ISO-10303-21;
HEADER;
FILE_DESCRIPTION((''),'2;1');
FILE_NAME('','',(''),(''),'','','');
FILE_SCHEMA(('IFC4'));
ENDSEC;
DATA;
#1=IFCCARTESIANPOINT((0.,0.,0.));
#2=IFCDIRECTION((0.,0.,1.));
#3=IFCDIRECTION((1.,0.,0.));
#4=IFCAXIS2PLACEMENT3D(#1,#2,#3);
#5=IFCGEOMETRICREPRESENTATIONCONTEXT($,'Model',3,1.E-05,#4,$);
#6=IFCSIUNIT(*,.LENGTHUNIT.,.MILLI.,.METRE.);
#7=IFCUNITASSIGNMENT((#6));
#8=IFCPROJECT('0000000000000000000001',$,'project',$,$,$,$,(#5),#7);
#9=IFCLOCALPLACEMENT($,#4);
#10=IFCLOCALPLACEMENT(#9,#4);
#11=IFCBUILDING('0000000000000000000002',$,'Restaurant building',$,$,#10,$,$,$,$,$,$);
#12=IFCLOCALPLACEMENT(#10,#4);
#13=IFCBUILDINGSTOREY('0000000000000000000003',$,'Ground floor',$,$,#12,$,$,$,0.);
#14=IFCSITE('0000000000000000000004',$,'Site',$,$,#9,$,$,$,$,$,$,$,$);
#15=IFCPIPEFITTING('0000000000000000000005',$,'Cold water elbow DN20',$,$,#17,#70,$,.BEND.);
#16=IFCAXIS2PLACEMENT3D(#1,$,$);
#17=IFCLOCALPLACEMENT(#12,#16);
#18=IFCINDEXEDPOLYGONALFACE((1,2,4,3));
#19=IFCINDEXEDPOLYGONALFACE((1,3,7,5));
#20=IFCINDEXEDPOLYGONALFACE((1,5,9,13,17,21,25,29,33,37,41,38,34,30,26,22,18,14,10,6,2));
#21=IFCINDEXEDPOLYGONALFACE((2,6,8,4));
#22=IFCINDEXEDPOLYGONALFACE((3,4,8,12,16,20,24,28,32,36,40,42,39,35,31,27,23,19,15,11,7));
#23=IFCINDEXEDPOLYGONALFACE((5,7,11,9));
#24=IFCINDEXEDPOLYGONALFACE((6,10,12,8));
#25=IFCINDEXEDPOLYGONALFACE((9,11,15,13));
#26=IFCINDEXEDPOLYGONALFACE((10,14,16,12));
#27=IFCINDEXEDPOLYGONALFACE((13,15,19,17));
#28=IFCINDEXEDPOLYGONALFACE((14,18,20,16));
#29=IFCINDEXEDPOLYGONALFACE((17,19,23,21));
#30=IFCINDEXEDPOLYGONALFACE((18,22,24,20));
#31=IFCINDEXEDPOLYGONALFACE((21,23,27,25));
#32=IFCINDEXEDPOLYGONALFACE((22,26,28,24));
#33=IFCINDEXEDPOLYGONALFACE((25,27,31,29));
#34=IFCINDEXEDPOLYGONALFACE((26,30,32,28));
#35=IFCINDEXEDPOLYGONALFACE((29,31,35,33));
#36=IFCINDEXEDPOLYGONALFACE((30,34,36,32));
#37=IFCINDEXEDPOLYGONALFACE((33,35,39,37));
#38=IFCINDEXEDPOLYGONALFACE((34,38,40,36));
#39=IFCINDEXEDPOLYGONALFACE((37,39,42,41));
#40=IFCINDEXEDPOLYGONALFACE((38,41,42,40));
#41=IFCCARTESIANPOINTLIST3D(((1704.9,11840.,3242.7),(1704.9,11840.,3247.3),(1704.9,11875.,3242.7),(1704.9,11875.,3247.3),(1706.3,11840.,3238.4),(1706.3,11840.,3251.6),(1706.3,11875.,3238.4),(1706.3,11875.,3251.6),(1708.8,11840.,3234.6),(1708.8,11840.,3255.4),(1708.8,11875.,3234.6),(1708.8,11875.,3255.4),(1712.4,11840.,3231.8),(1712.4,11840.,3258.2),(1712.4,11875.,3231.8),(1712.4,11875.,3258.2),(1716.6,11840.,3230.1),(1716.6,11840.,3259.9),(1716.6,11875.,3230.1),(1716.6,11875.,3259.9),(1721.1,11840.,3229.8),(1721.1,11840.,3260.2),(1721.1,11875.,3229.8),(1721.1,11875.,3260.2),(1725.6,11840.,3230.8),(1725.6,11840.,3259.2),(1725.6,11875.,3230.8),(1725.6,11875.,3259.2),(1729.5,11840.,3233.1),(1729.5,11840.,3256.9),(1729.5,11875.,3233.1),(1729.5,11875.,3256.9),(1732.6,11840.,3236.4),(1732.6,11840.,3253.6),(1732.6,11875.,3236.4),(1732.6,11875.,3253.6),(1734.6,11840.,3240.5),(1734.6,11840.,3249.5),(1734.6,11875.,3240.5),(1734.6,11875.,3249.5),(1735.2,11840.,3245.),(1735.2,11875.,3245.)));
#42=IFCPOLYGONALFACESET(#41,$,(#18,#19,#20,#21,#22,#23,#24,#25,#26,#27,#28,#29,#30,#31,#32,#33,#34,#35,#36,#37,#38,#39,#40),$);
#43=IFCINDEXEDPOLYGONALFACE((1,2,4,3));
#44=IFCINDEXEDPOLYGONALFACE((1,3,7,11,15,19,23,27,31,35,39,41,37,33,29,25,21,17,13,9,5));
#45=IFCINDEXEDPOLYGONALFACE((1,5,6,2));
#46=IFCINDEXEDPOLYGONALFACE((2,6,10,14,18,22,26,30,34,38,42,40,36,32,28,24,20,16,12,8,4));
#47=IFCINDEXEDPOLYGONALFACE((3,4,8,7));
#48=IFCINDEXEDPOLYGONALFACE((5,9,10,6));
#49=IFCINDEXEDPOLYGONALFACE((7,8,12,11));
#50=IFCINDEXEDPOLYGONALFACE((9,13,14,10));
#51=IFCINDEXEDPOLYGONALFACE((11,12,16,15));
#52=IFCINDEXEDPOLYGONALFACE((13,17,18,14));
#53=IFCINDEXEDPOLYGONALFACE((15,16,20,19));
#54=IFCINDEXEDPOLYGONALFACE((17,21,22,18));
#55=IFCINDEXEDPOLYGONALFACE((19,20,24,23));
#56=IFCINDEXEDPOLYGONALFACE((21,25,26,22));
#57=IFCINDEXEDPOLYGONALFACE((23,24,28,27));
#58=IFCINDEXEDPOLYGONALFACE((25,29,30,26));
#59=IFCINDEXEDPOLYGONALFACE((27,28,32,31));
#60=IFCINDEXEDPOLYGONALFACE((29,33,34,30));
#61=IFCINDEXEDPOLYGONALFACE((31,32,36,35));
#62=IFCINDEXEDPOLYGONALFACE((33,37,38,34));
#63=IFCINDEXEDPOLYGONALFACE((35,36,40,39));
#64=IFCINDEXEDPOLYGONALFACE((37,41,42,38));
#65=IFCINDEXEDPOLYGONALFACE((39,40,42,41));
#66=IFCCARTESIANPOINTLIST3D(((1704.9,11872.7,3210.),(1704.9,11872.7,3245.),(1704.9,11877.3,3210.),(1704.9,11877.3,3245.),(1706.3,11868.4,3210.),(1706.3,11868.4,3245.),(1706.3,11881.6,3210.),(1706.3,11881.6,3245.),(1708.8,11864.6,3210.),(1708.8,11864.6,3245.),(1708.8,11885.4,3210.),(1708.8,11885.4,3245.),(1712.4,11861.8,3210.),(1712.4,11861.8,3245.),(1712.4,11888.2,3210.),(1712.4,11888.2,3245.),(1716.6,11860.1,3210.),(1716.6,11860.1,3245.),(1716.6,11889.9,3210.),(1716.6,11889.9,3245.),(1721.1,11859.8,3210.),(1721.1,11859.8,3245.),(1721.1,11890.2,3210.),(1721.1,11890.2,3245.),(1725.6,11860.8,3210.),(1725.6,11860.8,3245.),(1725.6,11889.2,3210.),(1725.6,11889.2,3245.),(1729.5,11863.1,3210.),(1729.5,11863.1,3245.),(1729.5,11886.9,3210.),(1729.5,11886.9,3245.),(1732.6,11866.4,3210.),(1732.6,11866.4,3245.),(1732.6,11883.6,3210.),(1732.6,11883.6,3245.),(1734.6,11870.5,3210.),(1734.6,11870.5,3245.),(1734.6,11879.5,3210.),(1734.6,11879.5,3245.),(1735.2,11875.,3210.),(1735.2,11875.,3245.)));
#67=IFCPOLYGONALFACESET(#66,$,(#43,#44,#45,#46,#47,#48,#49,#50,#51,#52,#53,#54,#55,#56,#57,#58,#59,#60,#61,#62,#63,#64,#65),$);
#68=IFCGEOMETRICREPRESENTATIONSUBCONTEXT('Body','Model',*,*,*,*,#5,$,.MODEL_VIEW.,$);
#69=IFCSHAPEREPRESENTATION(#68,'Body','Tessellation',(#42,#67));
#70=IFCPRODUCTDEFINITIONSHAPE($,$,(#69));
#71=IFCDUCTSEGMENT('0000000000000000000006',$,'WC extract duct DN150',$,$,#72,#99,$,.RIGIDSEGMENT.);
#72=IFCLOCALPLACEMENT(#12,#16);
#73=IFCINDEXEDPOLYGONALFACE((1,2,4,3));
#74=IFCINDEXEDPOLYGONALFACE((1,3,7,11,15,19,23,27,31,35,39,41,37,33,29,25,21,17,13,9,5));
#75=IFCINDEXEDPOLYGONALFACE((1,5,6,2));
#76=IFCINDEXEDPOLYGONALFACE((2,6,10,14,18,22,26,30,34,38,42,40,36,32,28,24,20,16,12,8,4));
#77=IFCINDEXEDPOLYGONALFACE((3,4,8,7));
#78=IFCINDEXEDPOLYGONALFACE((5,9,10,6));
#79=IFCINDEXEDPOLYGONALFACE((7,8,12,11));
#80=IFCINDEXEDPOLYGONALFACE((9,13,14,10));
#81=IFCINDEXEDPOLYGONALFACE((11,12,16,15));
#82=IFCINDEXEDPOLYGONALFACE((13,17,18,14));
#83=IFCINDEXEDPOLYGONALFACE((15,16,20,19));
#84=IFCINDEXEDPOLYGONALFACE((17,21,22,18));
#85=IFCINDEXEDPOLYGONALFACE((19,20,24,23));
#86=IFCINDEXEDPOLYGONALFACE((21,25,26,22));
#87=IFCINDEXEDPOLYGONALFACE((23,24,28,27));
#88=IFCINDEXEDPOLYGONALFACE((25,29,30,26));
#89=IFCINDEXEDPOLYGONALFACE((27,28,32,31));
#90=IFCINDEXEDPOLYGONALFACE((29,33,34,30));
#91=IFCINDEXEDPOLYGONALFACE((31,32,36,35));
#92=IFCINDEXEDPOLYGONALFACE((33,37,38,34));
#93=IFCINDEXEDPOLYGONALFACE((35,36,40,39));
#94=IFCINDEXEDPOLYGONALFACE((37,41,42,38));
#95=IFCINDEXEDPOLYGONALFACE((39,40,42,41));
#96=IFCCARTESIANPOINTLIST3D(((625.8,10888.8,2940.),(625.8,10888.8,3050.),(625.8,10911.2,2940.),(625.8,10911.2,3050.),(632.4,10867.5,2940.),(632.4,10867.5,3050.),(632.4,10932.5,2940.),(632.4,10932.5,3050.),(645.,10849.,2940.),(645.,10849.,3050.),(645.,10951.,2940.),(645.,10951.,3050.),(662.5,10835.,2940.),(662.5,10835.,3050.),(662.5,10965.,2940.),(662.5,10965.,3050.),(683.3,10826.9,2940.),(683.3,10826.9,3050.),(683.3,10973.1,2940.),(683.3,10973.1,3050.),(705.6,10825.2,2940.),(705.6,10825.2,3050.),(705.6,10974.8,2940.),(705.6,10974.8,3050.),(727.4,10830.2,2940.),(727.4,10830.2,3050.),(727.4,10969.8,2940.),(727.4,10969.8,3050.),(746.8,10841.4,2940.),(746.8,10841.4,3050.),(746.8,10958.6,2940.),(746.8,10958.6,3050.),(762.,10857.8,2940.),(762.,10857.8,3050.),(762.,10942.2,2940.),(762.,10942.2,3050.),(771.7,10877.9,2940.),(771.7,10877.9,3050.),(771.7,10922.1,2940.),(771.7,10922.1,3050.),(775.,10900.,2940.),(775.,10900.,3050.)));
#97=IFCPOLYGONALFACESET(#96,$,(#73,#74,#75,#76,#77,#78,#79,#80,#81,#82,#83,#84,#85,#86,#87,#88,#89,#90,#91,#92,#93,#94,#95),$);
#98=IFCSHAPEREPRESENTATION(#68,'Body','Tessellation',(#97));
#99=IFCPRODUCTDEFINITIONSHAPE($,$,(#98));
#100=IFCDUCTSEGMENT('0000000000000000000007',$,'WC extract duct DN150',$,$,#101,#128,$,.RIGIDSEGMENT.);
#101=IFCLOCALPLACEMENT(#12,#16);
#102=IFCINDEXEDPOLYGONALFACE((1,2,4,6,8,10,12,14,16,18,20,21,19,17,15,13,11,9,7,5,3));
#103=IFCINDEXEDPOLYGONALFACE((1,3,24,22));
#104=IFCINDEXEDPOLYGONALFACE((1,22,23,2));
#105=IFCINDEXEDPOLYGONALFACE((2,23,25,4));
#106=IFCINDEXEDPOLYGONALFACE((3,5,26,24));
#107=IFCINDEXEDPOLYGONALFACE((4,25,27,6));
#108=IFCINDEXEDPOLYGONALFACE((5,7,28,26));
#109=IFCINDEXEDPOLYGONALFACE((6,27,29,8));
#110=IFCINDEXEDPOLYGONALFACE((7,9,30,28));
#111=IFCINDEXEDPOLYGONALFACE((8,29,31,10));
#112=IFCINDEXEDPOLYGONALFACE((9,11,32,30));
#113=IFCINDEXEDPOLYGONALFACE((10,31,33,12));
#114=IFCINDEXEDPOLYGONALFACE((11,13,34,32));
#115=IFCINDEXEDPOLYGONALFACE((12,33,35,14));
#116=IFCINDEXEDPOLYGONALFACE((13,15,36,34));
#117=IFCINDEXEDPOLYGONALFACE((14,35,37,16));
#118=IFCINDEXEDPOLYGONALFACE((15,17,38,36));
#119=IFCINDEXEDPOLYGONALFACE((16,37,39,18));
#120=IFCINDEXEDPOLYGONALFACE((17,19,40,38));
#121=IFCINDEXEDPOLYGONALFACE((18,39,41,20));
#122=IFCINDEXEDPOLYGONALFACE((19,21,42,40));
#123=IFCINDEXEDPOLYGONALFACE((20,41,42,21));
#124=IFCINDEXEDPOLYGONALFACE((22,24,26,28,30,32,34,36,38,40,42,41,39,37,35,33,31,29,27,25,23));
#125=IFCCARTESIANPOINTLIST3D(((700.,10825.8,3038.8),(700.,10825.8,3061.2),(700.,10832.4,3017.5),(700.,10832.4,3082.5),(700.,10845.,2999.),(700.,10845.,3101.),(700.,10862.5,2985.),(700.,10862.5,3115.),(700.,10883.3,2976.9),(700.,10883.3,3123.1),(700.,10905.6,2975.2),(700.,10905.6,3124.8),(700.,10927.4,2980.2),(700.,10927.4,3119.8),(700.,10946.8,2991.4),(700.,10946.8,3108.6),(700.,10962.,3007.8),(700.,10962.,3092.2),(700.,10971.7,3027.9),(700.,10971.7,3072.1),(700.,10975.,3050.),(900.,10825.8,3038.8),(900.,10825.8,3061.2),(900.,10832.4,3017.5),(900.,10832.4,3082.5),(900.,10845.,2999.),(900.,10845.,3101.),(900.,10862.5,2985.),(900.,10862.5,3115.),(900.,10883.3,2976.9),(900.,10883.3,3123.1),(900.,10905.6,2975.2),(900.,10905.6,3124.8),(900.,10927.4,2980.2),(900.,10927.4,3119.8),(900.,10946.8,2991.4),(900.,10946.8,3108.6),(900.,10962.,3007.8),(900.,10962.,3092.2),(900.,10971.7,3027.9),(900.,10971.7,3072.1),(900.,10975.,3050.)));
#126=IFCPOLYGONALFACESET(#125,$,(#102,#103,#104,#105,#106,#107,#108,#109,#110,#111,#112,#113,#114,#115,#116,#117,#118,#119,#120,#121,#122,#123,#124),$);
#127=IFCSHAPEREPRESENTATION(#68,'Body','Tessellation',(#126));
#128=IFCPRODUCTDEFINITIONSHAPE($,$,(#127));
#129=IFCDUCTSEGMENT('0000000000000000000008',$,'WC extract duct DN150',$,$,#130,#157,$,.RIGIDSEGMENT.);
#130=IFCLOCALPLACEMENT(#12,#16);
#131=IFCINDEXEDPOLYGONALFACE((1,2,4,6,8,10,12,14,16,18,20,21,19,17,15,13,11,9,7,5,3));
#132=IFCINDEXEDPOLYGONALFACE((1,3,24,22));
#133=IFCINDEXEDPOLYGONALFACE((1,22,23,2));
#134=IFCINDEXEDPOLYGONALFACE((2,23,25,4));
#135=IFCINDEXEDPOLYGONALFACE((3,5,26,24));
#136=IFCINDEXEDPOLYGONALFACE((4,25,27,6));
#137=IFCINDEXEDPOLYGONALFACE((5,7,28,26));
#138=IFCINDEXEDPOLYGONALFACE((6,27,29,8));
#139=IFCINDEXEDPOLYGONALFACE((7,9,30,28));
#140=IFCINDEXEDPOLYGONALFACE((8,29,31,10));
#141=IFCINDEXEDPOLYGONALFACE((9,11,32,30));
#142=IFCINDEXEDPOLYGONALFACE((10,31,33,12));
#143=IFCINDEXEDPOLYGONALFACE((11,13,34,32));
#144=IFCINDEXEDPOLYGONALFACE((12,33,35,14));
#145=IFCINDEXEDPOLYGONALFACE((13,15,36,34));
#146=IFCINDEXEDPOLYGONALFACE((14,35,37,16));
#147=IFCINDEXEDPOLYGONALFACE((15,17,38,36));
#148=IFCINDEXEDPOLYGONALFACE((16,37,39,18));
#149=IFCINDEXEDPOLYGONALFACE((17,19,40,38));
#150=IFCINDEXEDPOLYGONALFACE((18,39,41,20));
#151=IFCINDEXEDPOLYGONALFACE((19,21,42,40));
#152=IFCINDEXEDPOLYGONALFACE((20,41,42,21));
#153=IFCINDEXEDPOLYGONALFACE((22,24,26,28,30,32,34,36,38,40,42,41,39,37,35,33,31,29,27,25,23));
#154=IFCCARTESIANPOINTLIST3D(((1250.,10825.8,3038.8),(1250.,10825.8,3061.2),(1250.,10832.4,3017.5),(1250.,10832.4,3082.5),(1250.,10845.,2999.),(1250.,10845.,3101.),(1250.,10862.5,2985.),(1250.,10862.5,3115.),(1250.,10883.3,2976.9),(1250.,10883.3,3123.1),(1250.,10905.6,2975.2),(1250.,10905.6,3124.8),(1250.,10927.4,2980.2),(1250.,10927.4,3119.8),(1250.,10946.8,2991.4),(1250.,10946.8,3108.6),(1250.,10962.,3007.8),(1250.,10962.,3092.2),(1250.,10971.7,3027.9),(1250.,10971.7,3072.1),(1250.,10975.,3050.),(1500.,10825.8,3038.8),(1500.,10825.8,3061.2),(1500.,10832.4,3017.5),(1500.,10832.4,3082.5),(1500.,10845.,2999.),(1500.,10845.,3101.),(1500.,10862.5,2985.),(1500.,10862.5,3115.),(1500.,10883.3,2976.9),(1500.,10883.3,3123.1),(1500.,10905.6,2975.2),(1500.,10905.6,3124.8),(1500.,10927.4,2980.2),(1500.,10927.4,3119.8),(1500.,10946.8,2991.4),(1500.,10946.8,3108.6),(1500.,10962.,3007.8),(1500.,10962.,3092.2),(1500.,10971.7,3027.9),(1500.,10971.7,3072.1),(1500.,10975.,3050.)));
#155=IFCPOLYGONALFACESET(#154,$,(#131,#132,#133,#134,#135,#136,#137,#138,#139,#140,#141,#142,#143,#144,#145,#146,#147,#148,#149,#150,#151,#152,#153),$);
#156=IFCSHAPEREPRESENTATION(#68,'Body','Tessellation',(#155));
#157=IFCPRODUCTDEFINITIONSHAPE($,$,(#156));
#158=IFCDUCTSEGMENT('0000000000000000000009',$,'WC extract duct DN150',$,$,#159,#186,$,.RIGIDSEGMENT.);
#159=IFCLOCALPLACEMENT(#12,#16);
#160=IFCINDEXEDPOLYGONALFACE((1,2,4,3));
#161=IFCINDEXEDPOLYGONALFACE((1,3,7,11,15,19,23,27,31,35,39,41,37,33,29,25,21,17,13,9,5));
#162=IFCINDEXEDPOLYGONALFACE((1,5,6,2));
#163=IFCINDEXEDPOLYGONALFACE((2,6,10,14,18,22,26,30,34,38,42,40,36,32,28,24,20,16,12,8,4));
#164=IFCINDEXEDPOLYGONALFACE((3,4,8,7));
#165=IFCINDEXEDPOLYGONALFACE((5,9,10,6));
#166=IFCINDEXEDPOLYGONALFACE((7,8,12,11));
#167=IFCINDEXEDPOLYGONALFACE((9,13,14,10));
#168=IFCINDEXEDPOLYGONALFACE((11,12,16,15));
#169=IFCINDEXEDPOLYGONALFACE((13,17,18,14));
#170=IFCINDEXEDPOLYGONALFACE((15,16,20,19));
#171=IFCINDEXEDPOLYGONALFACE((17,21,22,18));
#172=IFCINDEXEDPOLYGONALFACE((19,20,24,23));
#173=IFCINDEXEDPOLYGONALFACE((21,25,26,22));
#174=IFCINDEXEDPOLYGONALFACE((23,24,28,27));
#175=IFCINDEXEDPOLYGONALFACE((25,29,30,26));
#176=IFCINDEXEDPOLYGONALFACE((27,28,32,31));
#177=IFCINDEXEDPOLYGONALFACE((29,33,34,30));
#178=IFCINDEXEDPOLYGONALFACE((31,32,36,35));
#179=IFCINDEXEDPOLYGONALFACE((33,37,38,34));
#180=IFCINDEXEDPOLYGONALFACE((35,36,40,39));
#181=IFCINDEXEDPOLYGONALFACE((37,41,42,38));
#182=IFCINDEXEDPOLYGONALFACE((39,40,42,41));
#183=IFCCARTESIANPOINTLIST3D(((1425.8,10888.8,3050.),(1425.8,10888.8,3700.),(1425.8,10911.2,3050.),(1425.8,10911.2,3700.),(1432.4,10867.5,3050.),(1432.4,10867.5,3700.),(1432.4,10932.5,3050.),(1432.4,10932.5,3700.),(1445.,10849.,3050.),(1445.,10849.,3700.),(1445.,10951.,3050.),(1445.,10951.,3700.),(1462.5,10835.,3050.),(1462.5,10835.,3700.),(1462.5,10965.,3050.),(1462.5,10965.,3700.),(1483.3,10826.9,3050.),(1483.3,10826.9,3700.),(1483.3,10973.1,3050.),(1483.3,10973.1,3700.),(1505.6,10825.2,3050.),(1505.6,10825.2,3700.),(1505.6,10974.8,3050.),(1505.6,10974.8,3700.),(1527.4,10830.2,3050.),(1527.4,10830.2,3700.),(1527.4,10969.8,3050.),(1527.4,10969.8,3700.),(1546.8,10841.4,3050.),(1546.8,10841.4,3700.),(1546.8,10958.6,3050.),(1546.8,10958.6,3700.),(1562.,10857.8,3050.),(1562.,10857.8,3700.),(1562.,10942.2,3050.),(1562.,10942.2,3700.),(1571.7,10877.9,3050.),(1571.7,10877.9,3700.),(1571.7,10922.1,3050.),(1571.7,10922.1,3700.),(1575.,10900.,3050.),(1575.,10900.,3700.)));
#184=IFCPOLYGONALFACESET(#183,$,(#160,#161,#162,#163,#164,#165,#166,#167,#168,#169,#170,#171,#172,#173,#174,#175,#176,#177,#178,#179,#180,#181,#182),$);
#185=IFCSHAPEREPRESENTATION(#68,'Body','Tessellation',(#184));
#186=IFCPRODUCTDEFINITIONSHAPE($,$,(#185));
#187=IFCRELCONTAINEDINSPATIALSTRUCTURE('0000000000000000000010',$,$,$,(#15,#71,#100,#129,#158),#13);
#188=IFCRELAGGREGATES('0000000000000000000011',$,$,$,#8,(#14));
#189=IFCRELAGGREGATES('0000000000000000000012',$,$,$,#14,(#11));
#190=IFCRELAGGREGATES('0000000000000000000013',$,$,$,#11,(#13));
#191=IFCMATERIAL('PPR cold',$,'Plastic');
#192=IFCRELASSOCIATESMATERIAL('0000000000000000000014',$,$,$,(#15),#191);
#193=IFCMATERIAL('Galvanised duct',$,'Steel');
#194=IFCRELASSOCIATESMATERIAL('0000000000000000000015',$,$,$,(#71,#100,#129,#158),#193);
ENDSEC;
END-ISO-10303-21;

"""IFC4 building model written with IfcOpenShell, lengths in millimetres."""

from ifc_helpers import new_model, si_unit, frame, origin, origin_with_axes, origin_2d, place, context, subcontext, project, spatial, circle, extrude, material, element, save


model = new_model("IFC4")

# Units and contexts
model_context = context("Model", 3, precision=1e-05, world=origin_with_axes())
body_context = subcontext(model_context, "Body", "Model", "MODEL_VIEW")
ifc_project = project(units=[si_unit("LENGTHUNIT", "METRE", prefix="MILLI")], contexts=[model_context])

# Site, building, storey
site_placement = place(None, origin_with_axes())
site = spatial("IfcSite", under=ifc_project, at=site_placement, Name="Site")
building_placement = place(site_placement, origin_with_axes())
building = spatial("IfcBuilding", under=site, at=building_placement, Name="Restaurant building")
storey_placement = place(building_placement, origin_with_axes())
storey = spatial("IfcBuildingStorey", under=building, at=storey_placement, Name="Ground floor", Elevation=0.0)

# Shared definitions
ifc_material_1 = material(Name="PPR cold", Category="Plastic")

# Pipe fitting
pipe_fitting_1_placement = place(storey_placement, frame((1720.0, 11875.0, 3245.0)))
element("IfcPipeFitting", 1, at=pipe_fitting_1_placement, inside=storey, material=ifc_material_1, Name="Cold water elbow DN20", PredefinedType="BEND", context=body_context, shape_type="SweptSolid", body=[
    extrude(circle(Radius=15.2, at=origin_2d()), frame((0.0, 0.0, 0.0), z_axis=(0.0, -1.0, 0.0), x_axis=(1.0, 0.0, 0.0)), (0.0, 0.0, 1.0), 35.0),
    extrude(circle(Radius=15.2, at=origin_2d()), frame((0.0, 0.0, 0.0), z_axis=(0.0, 0.0, -1.0), x_axis=(1.0, 0.0, 0.0)), (0.0, 0.0, 1.0), 35.0),
])

# Duct segments
ifc_material_2 = material(Name="Galvanised duct", Category="Steel")
duct_segment_1_placement = place(storey_placement, frame((700.0, 10900.0, 2940.0)))
element("IfcDuctSegment", 2, at=duct_segment_1_placement, inside=storey, material=ifc_material_2, Name="WC extract duct DN150", PredefinedType="RIGIDSEGMENT", context=body_context, shape_type="SweptSolid", body=[
    extrude(circle(Radius=75.0, at=origin_2d()), origin(), (0.0, 0.0, 1.0), 110.0),
])
duct_segment_2_placement = place(storey_placement, frame((700.0, 10900.0, 3050.0)))
element("IfcDuctSegment", 3, at=duct_segment_2_placement, inside=storey, material=ifc_material_2, Name="WC extract duct DN150", PredefinedType="RIGIDSEGMENT", context=body_context, shape_type="SweptSolid", body=[
    extrude(circle(Radius=75.0, at=origin_2d()), frame((0.0, 0.0, 0.0), z_axis=(1.0, 0.0, 0.0), x_axis=(0.0, 1.0, 0.0)), (0.0, 0.0, 1.0), 200.0),
])
duct_segment_3_placement = place(storey_placement, frame((1250.0, 10900.0, 3050.0)))
element("IfcDuctSegment", 4, at=duct_segment_3_placement, inside=storey, material=ifc_material_2, Name="WC extract duct DN150", PredefinedType="RIGIDSEGMENT", context=body_context, shape_type="SweptSolid", body=[
    extrude(circle(Radius=75.0, at=origin_2d()), frame((0.0, 0.0, 0.0), z_axis=(1.0, 0.0, 0.0), x_axis=(0.0, 1.0, 0.0)), (0.0, 0.0, 1.0), 250.0),
])
duct_segment_4_placement = place(storey_placement, frame((1500.0, 10900.0, 3050.0)))
element("IfcDuctSegment", 5, at=duct_segment_4_placement, inside=storey, material=ifc_material_2, Name="WC extract duct DN150", PredefinedType="RIGIDSEGMENT", context=body_context, shape_type="SweptSolid", body=[
    extrude(circle(Radius=75.0, at=origin_2d()), origin(), (0.0, 0.0, 1.0), 650.0),
])

save(model, "model.ifc")
